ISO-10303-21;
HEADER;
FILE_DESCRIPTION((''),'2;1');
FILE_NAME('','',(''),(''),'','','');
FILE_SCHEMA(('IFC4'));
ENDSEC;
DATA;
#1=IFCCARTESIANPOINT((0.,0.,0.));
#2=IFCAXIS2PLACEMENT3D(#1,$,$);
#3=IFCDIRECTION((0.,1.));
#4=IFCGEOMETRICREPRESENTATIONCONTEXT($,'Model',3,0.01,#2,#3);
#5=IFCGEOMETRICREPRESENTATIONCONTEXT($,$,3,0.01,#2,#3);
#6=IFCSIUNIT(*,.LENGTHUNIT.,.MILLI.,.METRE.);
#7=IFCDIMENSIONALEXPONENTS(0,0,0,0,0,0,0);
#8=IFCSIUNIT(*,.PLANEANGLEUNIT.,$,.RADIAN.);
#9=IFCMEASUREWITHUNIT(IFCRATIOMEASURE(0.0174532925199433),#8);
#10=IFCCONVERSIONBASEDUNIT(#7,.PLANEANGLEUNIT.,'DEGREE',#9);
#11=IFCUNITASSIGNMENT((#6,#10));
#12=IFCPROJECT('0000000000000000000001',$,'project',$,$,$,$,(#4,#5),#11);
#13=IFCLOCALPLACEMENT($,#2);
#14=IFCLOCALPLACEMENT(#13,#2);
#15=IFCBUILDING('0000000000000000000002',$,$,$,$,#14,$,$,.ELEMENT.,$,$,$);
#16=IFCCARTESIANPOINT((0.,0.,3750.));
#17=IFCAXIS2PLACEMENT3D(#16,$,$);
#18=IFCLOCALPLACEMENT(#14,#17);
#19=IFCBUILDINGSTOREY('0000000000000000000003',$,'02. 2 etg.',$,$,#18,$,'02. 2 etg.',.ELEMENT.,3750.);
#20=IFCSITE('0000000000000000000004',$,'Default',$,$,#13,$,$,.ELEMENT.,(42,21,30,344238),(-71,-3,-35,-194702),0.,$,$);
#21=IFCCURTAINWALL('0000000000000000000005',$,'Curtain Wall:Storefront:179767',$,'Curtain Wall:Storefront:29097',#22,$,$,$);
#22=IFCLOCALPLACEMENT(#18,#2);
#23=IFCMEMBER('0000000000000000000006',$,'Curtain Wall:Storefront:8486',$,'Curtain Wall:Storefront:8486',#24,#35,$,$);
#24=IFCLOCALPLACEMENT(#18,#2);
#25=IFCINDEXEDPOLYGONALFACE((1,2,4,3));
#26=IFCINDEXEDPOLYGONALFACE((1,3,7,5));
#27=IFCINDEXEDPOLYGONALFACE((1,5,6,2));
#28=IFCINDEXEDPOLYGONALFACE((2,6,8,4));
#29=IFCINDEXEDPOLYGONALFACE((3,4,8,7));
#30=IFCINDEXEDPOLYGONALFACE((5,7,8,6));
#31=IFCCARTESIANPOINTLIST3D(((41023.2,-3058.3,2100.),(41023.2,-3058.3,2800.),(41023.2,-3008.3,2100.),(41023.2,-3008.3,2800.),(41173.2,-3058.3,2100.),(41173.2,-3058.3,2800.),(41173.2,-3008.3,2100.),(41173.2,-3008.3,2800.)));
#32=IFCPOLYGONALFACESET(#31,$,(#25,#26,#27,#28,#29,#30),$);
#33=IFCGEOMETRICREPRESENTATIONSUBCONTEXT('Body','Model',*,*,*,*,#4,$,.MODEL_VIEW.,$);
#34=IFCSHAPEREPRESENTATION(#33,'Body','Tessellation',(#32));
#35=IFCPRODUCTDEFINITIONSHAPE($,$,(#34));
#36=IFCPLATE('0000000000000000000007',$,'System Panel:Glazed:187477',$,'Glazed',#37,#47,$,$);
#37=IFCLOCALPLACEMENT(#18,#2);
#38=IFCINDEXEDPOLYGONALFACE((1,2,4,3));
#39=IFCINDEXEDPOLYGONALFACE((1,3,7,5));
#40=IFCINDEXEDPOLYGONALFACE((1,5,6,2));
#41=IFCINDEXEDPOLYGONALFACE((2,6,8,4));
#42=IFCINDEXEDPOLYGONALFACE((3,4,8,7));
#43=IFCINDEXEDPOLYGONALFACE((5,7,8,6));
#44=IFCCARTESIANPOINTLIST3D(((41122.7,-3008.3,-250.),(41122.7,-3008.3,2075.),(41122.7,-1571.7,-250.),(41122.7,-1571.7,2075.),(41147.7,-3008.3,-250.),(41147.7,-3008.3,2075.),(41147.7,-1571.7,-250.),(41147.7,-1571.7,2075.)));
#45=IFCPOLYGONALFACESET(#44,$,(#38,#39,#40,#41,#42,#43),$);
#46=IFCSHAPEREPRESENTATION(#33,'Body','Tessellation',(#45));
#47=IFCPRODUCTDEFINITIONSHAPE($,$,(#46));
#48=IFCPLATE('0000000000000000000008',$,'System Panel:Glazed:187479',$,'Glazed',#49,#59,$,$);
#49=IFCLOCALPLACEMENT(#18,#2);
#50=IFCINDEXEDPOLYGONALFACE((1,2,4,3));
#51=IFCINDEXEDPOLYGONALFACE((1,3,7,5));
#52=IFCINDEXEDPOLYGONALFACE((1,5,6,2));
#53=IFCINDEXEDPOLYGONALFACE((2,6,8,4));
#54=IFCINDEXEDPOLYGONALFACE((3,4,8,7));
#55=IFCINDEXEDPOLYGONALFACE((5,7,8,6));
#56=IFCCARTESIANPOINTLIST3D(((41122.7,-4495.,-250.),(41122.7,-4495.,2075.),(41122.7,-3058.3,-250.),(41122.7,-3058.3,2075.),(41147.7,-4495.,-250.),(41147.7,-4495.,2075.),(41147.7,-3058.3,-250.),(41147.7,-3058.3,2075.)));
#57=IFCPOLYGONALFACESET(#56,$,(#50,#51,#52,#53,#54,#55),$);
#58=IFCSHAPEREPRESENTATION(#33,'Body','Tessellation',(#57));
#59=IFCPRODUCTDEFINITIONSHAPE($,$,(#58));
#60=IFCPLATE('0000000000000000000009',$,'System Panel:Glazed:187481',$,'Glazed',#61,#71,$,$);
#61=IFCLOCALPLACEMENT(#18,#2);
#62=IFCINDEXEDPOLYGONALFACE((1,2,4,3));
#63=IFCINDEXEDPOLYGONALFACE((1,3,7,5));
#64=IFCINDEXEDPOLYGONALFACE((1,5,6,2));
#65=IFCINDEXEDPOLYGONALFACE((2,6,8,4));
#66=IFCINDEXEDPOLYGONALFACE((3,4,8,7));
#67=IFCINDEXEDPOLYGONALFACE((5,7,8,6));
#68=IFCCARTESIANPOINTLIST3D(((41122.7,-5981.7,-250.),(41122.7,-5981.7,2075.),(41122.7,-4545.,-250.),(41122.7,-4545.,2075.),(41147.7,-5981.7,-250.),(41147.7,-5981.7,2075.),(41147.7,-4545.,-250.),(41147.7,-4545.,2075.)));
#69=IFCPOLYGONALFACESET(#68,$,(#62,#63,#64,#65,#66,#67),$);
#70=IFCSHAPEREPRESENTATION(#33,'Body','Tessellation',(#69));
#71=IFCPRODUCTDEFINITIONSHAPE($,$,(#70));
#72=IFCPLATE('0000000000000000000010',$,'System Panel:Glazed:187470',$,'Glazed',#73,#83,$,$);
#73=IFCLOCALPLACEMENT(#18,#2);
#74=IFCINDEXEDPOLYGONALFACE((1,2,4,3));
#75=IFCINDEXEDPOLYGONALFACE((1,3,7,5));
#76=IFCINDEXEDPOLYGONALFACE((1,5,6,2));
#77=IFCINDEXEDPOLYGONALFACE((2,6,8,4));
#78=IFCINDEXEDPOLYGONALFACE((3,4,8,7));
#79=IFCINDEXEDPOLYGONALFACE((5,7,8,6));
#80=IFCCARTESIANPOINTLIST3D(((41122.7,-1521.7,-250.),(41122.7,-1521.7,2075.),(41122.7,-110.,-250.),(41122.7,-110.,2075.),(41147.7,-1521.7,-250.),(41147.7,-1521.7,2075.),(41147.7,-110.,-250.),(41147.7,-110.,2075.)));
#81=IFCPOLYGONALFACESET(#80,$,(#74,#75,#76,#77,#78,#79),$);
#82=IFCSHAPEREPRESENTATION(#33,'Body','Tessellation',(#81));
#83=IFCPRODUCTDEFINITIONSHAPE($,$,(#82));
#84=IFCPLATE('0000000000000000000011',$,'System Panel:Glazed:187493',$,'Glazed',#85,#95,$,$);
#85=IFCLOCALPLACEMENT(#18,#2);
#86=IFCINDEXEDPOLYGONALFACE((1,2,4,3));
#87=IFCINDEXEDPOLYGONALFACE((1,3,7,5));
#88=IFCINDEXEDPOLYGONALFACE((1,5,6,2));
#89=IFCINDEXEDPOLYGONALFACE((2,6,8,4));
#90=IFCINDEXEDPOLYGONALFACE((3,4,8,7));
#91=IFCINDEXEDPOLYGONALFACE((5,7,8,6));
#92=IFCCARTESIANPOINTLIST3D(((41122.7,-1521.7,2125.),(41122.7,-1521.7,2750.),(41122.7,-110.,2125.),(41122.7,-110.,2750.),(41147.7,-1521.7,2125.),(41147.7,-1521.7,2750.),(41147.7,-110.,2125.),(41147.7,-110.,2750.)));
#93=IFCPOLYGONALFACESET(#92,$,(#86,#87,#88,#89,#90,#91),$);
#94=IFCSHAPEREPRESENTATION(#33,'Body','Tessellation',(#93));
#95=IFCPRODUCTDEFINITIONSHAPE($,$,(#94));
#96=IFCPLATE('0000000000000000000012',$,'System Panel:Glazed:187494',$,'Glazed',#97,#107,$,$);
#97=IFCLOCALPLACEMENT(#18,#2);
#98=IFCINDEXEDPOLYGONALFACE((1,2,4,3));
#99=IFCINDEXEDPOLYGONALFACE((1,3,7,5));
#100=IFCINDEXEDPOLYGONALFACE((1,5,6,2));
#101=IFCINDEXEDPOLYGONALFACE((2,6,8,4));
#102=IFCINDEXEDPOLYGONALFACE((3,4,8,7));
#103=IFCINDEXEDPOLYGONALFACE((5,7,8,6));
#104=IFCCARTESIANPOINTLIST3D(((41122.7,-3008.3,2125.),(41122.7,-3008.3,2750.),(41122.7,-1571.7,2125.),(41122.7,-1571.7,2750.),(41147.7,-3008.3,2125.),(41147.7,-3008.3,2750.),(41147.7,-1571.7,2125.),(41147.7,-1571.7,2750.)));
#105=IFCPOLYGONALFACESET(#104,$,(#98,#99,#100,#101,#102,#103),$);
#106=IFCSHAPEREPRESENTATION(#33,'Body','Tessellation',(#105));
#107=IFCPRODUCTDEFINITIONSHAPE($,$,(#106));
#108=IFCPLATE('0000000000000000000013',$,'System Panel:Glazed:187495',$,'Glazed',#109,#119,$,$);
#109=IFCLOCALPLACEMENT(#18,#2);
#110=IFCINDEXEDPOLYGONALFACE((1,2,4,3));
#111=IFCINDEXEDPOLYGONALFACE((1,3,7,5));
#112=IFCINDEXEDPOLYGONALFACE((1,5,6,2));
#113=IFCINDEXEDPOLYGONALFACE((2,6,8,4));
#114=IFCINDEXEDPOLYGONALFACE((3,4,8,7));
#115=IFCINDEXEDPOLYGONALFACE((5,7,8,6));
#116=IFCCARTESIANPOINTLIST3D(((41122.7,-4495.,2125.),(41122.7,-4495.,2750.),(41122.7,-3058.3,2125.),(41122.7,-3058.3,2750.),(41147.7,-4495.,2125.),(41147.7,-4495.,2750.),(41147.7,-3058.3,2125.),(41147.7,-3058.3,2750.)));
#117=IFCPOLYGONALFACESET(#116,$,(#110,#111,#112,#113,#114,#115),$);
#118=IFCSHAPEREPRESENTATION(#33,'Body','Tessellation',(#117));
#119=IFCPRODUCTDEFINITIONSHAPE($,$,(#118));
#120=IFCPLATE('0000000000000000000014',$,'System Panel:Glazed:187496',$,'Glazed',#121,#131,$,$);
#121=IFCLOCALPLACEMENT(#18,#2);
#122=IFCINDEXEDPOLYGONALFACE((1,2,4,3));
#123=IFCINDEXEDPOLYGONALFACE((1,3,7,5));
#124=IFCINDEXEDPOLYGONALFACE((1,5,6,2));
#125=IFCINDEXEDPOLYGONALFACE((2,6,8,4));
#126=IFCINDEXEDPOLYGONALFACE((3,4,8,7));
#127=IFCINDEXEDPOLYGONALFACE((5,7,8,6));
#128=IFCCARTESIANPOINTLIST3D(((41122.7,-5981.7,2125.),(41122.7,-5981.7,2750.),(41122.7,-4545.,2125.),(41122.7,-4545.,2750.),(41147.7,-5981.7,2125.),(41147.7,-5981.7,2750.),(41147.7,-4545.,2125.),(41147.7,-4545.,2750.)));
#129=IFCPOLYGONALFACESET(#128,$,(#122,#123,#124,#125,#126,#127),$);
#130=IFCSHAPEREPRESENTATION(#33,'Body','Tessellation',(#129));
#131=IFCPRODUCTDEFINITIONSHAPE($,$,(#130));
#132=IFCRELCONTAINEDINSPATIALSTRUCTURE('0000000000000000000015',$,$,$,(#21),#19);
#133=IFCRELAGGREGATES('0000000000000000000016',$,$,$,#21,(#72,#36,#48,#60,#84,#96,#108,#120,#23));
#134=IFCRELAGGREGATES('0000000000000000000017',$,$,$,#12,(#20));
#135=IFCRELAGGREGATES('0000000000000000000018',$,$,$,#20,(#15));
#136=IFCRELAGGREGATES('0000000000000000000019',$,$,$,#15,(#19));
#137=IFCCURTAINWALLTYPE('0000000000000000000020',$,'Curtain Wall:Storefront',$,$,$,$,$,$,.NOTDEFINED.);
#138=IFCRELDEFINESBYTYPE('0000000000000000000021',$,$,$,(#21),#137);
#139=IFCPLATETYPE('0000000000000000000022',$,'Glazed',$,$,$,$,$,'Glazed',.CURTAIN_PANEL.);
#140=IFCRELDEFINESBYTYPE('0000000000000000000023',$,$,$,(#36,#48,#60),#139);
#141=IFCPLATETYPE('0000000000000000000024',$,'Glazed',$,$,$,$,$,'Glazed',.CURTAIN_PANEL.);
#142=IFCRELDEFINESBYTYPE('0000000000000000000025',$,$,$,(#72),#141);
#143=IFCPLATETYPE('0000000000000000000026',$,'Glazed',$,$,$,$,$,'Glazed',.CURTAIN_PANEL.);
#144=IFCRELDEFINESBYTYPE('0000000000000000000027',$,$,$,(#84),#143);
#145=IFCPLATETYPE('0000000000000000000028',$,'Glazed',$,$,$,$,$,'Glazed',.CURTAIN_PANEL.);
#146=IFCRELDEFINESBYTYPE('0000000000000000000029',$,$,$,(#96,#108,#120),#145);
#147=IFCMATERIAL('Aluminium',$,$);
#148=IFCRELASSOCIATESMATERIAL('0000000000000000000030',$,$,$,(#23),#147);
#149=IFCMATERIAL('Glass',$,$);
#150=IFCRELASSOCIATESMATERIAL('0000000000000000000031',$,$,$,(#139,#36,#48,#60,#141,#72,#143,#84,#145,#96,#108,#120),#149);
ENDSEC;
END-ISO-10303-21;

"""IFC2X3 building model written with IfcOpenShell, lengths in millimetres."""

from ifc_helpers import new_model, entity, si_unit, converted_unit, direction, frame, origin, origin_2d_with_axis, place, context, subcontext, project, spatial, rectangle, extrude, source, transform, mapped, material, type_object, type_shapes, element, aggregate, save


model = new_model("IFC2X3")

# Units and contexts
model_context = context("Model", 3, precision=0.01, world=origin(), true_north=direction((0.0, 1.0)))
context_of_model = context(None, 3, precision=0.01, world=origin(), true_north=direction((0.0, 1.0)))
body_context = subcontext(model_context, "Body", "Model", "MODEL_VIEW")
ifc_project = project(units=[si_unit("LENGTHUNIT", "METRE", prefix="MILLI"), converted_unit("PLANEANGLEUNIT", "DEGREE", entity("IfcRatioMeasure", 0.0174532925199433), si_unit("PLANEANGLEUNIT", "RADIAN"), dimensions=[0, 0, 0, 0, 0, 0, 0])], contexts=[model_context, context_of_model])

# Site, building, storey
site_placement = place(None, origin())
site = spatial("IfcSite", under=ifc_project, at=site_placement, Name="Default", CompositionType="ELEMENT", RefLatitude=(42, 21, 30, 344238), RefLongitude=(-71, -3, -35, -194702), RefElevation=0.0)
building_placement = place(site_placement, origin())
building = spatial("IfcBuilding", under=site, at=building_placement, CompositionType="ELEMENT")
storey_placement = place(building_placement, frame((0.0, 0.0, 3750.0)))
storey = spatial("IfcBuildingStorey", under=building, at=storey_placement, Name="02. 2 etg.", LongName="02. 2 etg.", CompositionType="ELEMENT", Elevation=3750.0)

# Curtain wall, member, plates
curtain_wall_type = type_object("IfcCurtainWallType", Name="Curtain Wall:Storefront", PredefinedType="NOTDEFINED")
curtain_wall_placement = place(storey_placement, frame((0.0, 0.0, -3750.0)))
curtain_wall = element("IfcCurtainWall", 1, at=curtain_wall_placement, inside=storey, type_object=curtain_wall_type, Name="Curtain Wall:Storefront:179767", ObjectType="Curtain Wall:Storefront:29097")
ifc_material_1 = material(Name="Aluminium")
member_1_placement = place(curtain_wall_placement, frame((41023.2, -3058.3, 5850.0)))
member_1 = element("IfcMember", 2, at=member_1_placement, material=ifc_material_1, Name="Curtain Wall:Storefront:8486", ObjectType="Curtain Wall:Storefront:8486", context=body_context, shape_type="SweptSolid", body=[
    extrude(rectangle(XDim=150.0, YDim=50.0, at=origin_2d_with_axis()), frame((75.0, 25.0, 0.0)), (0.0, 0.0, 1.0), 700.0),
])
ifc_material_2 = material(Name="Glass")
plate_type_1 = type_object("IfcPlateType", Name="Glazed", ElementType="Glazed", PredefinedType="CURTAIN_PANEL", material=ifc_material_2)
shared_shape_1 = source(origin(), body_context, "Body", "SweptSolid", [
    extrude(rectangle(XDim=25.0, YDim=1436.7, at=origin_2d_with_axis()), frame((718.3, 12.5, 0.0), z_axis=(0.0, 0.0, 1.0), x_axis=(0.0, 1.0, 0.0)), (0.0, 0.0, 1.0), 2325.0),
])
type_shapes(plate_type_1, [shared_shape_1])
plate_1_placement = place(curtain_wall_placement, frame((41122.7, -1571.7, 3500.0), z_axis=(0.0, 0.0, 1.0), x_axis=(0.0, -1.0, 0.0)))
plate_1 = element("IfcPlate", 3, at=plate_1_placement, type_object=plate_type_1, material=ifc_material_2, Name="System Panel:Glazed:187477", ObjectType="Glazed", context=body_context, shape_type="MappedRepresentation", body=[
    mapped(shared_shape_1, transform((0.0, 0.0, 0.0), scale=1.0)),
])
plate_2_placement = place(curtain_wall_placement, frame((41122.7, -3058.3, 3500.0), z_axis=(0.0, 0.0, 1.0), x_axis=(0.0, -1.0, 0.0)))
plate_2 = element("IfcPlate", 4, at=plate_2_placement, type_object=plate_type_1, material=ifc_material_2, Name="System Panel:Glazed:187479", ObjectType="Glazed", context=body_context, shape_type="MappedRepresentation", body=[
    mapped(shared_shape_1, transform((0.0, 0.0, 0.0), scale=1.0)),
])
plate_3_placement = place(curtain_wall_placement, frame((41122.7, -4545.0, 3500.0), z_axis=(0.0, 0.0, 1.0), x_axis=(0.0, -1.0, 0.0)))
plate_3 = element("IfcPlate", 5, at=plate_3_placement, type_object=plate_type_1, material=ifc_material_2, Name="System Panel:Glazed:187481", ObjectType="Glazed", context=body_context, shape_type="MappedRepresentation", body=[
    mapped(shared_shape_1, transform((0.0, 0.0, 0.0), scale=1.0)),
])
plate_type_2 = type_object("IfcPlateType", Name="Glazed", ElementType="Glazed", PredefinedType="CURTAIN_PANEL", material=ifc_material_2)
shared_shape_2 = source(origin(), body_context, "Body", "SweptSolid", [
    extrude(rectangle(XDim=25.0, YDim=1411.7, at=origin_2d_with_axis()), frame((705.8, 12.5, 0.0), z_axis=(0.0, 0.0, 1.0), x_axis=(0.0, 1.0, 0.0)), (0.0, 0.0, 1.0), 2325.0),
])
type_shapes(plate_type_2, [shared_shape_2])
plate_4_placement = place(curtain_wall_placement, frame((41122.7, -110.0, 3500.0), z_axis=(0.0, 0.0, 1.0), x_axis=(0.0, -1.0, 0.0)))
plate_4 = element("IfcPlate", 6, at=plate_4_placement, type_object=plate_type_2, material=ifc_material_2, Name="System Panel:Glazed:187470", ObjectType="Glazed", context=body_context, shape_type="MappedRepresentation", body=[
    mapped(shared_shape_2, transform((0.0, 0.0, 0.0), scale=1.0)),
])
plate_type_3 = type_object("IfcPlateType", Name="Glazed", ElementType="Glazed", PredefinedType="CURTAIN_PANEL", material=ifc_material_2)
shared_shape_3 = source(origin(), body_context, "Body", "SweptSolid", [
    extrude(rectangle(XDim=25.0, YDim=1411.7, at=origin_2d_with_axis()), frame((705.8, 12.5, 0.0), z_axis=(0.0, 0.0, 1.0), x_axis=(0.0, 1.0, 0.0)), (0.0, 0.0, 1.0), 625.0),
])
type_shapes(plate_type_3, [shared_shape_3])
plate_5_placement = place(curtain_wall_placement, frame((41122.7, -110.0, 5875.0), z_axis=(0.0, 0.0, 1.0), x_axis=(0.0, -1.0, 0.0)))
plate_5 = element("IfcPlate", 7, at=plate_5_placement, type_object=plate_type_3, material=ifc_material_2, Name="System Panel:Glazed:187493", ObjectType="Glazed", context=body_context, shape_type="MappedRepresentation", body=[
    mapped(shared_shape_3, transform((0.0, 0.0, 0.0), scale=1.0)),
])
plate_type_4 = type_object("IfcPlateType", Name="Glazed", ElementType="Glazed", PredefinedType="CURTAIN_PANEL", material=ifc_material_2)
shared_shape_4 = source(origin(), body_context, "Body", "SweptSolid", [
    extrude(rectangle(XDim=25.0, YDim=1436.7, at=origin_2d_with_axis()), frame((718.3, 12.5, 0.0), z_axis=(0.0, 0.0, 1.0), x_axis=(0.0, 1.0, 0.0)), (0.0, 0.0, 1.0), 625.0),
])
type_shapes(plate_type_4, [shared_shape_4])
plate_6_placement = place(curtain_wall_placement, frame((41122.7, -1571.7, 5875.0), z_axis=(0.0, 0.0, 1.0), x_axis=(0.0, -1.0, 0.0)))
plate_6 = element("IfcPlate", 8, at=plate_6_placement, type_object=plate_type_4, material=ifc_material_2, Name="System Panel:Glazed:187494", ObjectType="Glazed", context=body_context, shape_type="MappedRepresentation", body=[
    mapped(shared_shape_4, transform((0.0, 0.0, 0.0), scale=1.0)),
])
plate_7_placement = place(curtain_wall_placement, frame((41122.7, -3058.3, 5875.0), z_axis=(0.0, 0.0, 1.0), x_axis=(0.0, -1.0, 0.0)))
plate_7 = element("IfcPlate", 9, at=plate_7_placement, type_object=plate_type_4, material=ifc_material_2, Name="System Panel:Glazed:187495", ObjectType="Glazed", context=body_context, shape_type="MappedRepresentation", body=[
    mapped(shared_shape_4, transform((0.0, 0.0, 0.0), scale=1.0)),
])
plate_8_placement = place(curtain_wall_placement, frame((41122.7, -4545.0, 5875.0), z_axis=(0.0, 0.0, 1.0), x_axis=(0.0, -1.0, 0.0)))
plate_8 = element("IfcPlate", 10, at=plate_8_placement, type_object=plate_type_4, material=ifc_material_2, Name="System Panel:Glazed:187496", ObjectType="Glazed", context=body_context, shape_type="MappedRepresentation", body=[
    mapped(shared_shape_4, transform((0.0, 0.0, 0.0), scale=1.0)),
])
aggregate(curtain_wall, [plate_4, plate_1, plate_2, plate_3, plate_5, plate_6, plate_7, plate_8, member_1])

save(model, "model.ifc")
